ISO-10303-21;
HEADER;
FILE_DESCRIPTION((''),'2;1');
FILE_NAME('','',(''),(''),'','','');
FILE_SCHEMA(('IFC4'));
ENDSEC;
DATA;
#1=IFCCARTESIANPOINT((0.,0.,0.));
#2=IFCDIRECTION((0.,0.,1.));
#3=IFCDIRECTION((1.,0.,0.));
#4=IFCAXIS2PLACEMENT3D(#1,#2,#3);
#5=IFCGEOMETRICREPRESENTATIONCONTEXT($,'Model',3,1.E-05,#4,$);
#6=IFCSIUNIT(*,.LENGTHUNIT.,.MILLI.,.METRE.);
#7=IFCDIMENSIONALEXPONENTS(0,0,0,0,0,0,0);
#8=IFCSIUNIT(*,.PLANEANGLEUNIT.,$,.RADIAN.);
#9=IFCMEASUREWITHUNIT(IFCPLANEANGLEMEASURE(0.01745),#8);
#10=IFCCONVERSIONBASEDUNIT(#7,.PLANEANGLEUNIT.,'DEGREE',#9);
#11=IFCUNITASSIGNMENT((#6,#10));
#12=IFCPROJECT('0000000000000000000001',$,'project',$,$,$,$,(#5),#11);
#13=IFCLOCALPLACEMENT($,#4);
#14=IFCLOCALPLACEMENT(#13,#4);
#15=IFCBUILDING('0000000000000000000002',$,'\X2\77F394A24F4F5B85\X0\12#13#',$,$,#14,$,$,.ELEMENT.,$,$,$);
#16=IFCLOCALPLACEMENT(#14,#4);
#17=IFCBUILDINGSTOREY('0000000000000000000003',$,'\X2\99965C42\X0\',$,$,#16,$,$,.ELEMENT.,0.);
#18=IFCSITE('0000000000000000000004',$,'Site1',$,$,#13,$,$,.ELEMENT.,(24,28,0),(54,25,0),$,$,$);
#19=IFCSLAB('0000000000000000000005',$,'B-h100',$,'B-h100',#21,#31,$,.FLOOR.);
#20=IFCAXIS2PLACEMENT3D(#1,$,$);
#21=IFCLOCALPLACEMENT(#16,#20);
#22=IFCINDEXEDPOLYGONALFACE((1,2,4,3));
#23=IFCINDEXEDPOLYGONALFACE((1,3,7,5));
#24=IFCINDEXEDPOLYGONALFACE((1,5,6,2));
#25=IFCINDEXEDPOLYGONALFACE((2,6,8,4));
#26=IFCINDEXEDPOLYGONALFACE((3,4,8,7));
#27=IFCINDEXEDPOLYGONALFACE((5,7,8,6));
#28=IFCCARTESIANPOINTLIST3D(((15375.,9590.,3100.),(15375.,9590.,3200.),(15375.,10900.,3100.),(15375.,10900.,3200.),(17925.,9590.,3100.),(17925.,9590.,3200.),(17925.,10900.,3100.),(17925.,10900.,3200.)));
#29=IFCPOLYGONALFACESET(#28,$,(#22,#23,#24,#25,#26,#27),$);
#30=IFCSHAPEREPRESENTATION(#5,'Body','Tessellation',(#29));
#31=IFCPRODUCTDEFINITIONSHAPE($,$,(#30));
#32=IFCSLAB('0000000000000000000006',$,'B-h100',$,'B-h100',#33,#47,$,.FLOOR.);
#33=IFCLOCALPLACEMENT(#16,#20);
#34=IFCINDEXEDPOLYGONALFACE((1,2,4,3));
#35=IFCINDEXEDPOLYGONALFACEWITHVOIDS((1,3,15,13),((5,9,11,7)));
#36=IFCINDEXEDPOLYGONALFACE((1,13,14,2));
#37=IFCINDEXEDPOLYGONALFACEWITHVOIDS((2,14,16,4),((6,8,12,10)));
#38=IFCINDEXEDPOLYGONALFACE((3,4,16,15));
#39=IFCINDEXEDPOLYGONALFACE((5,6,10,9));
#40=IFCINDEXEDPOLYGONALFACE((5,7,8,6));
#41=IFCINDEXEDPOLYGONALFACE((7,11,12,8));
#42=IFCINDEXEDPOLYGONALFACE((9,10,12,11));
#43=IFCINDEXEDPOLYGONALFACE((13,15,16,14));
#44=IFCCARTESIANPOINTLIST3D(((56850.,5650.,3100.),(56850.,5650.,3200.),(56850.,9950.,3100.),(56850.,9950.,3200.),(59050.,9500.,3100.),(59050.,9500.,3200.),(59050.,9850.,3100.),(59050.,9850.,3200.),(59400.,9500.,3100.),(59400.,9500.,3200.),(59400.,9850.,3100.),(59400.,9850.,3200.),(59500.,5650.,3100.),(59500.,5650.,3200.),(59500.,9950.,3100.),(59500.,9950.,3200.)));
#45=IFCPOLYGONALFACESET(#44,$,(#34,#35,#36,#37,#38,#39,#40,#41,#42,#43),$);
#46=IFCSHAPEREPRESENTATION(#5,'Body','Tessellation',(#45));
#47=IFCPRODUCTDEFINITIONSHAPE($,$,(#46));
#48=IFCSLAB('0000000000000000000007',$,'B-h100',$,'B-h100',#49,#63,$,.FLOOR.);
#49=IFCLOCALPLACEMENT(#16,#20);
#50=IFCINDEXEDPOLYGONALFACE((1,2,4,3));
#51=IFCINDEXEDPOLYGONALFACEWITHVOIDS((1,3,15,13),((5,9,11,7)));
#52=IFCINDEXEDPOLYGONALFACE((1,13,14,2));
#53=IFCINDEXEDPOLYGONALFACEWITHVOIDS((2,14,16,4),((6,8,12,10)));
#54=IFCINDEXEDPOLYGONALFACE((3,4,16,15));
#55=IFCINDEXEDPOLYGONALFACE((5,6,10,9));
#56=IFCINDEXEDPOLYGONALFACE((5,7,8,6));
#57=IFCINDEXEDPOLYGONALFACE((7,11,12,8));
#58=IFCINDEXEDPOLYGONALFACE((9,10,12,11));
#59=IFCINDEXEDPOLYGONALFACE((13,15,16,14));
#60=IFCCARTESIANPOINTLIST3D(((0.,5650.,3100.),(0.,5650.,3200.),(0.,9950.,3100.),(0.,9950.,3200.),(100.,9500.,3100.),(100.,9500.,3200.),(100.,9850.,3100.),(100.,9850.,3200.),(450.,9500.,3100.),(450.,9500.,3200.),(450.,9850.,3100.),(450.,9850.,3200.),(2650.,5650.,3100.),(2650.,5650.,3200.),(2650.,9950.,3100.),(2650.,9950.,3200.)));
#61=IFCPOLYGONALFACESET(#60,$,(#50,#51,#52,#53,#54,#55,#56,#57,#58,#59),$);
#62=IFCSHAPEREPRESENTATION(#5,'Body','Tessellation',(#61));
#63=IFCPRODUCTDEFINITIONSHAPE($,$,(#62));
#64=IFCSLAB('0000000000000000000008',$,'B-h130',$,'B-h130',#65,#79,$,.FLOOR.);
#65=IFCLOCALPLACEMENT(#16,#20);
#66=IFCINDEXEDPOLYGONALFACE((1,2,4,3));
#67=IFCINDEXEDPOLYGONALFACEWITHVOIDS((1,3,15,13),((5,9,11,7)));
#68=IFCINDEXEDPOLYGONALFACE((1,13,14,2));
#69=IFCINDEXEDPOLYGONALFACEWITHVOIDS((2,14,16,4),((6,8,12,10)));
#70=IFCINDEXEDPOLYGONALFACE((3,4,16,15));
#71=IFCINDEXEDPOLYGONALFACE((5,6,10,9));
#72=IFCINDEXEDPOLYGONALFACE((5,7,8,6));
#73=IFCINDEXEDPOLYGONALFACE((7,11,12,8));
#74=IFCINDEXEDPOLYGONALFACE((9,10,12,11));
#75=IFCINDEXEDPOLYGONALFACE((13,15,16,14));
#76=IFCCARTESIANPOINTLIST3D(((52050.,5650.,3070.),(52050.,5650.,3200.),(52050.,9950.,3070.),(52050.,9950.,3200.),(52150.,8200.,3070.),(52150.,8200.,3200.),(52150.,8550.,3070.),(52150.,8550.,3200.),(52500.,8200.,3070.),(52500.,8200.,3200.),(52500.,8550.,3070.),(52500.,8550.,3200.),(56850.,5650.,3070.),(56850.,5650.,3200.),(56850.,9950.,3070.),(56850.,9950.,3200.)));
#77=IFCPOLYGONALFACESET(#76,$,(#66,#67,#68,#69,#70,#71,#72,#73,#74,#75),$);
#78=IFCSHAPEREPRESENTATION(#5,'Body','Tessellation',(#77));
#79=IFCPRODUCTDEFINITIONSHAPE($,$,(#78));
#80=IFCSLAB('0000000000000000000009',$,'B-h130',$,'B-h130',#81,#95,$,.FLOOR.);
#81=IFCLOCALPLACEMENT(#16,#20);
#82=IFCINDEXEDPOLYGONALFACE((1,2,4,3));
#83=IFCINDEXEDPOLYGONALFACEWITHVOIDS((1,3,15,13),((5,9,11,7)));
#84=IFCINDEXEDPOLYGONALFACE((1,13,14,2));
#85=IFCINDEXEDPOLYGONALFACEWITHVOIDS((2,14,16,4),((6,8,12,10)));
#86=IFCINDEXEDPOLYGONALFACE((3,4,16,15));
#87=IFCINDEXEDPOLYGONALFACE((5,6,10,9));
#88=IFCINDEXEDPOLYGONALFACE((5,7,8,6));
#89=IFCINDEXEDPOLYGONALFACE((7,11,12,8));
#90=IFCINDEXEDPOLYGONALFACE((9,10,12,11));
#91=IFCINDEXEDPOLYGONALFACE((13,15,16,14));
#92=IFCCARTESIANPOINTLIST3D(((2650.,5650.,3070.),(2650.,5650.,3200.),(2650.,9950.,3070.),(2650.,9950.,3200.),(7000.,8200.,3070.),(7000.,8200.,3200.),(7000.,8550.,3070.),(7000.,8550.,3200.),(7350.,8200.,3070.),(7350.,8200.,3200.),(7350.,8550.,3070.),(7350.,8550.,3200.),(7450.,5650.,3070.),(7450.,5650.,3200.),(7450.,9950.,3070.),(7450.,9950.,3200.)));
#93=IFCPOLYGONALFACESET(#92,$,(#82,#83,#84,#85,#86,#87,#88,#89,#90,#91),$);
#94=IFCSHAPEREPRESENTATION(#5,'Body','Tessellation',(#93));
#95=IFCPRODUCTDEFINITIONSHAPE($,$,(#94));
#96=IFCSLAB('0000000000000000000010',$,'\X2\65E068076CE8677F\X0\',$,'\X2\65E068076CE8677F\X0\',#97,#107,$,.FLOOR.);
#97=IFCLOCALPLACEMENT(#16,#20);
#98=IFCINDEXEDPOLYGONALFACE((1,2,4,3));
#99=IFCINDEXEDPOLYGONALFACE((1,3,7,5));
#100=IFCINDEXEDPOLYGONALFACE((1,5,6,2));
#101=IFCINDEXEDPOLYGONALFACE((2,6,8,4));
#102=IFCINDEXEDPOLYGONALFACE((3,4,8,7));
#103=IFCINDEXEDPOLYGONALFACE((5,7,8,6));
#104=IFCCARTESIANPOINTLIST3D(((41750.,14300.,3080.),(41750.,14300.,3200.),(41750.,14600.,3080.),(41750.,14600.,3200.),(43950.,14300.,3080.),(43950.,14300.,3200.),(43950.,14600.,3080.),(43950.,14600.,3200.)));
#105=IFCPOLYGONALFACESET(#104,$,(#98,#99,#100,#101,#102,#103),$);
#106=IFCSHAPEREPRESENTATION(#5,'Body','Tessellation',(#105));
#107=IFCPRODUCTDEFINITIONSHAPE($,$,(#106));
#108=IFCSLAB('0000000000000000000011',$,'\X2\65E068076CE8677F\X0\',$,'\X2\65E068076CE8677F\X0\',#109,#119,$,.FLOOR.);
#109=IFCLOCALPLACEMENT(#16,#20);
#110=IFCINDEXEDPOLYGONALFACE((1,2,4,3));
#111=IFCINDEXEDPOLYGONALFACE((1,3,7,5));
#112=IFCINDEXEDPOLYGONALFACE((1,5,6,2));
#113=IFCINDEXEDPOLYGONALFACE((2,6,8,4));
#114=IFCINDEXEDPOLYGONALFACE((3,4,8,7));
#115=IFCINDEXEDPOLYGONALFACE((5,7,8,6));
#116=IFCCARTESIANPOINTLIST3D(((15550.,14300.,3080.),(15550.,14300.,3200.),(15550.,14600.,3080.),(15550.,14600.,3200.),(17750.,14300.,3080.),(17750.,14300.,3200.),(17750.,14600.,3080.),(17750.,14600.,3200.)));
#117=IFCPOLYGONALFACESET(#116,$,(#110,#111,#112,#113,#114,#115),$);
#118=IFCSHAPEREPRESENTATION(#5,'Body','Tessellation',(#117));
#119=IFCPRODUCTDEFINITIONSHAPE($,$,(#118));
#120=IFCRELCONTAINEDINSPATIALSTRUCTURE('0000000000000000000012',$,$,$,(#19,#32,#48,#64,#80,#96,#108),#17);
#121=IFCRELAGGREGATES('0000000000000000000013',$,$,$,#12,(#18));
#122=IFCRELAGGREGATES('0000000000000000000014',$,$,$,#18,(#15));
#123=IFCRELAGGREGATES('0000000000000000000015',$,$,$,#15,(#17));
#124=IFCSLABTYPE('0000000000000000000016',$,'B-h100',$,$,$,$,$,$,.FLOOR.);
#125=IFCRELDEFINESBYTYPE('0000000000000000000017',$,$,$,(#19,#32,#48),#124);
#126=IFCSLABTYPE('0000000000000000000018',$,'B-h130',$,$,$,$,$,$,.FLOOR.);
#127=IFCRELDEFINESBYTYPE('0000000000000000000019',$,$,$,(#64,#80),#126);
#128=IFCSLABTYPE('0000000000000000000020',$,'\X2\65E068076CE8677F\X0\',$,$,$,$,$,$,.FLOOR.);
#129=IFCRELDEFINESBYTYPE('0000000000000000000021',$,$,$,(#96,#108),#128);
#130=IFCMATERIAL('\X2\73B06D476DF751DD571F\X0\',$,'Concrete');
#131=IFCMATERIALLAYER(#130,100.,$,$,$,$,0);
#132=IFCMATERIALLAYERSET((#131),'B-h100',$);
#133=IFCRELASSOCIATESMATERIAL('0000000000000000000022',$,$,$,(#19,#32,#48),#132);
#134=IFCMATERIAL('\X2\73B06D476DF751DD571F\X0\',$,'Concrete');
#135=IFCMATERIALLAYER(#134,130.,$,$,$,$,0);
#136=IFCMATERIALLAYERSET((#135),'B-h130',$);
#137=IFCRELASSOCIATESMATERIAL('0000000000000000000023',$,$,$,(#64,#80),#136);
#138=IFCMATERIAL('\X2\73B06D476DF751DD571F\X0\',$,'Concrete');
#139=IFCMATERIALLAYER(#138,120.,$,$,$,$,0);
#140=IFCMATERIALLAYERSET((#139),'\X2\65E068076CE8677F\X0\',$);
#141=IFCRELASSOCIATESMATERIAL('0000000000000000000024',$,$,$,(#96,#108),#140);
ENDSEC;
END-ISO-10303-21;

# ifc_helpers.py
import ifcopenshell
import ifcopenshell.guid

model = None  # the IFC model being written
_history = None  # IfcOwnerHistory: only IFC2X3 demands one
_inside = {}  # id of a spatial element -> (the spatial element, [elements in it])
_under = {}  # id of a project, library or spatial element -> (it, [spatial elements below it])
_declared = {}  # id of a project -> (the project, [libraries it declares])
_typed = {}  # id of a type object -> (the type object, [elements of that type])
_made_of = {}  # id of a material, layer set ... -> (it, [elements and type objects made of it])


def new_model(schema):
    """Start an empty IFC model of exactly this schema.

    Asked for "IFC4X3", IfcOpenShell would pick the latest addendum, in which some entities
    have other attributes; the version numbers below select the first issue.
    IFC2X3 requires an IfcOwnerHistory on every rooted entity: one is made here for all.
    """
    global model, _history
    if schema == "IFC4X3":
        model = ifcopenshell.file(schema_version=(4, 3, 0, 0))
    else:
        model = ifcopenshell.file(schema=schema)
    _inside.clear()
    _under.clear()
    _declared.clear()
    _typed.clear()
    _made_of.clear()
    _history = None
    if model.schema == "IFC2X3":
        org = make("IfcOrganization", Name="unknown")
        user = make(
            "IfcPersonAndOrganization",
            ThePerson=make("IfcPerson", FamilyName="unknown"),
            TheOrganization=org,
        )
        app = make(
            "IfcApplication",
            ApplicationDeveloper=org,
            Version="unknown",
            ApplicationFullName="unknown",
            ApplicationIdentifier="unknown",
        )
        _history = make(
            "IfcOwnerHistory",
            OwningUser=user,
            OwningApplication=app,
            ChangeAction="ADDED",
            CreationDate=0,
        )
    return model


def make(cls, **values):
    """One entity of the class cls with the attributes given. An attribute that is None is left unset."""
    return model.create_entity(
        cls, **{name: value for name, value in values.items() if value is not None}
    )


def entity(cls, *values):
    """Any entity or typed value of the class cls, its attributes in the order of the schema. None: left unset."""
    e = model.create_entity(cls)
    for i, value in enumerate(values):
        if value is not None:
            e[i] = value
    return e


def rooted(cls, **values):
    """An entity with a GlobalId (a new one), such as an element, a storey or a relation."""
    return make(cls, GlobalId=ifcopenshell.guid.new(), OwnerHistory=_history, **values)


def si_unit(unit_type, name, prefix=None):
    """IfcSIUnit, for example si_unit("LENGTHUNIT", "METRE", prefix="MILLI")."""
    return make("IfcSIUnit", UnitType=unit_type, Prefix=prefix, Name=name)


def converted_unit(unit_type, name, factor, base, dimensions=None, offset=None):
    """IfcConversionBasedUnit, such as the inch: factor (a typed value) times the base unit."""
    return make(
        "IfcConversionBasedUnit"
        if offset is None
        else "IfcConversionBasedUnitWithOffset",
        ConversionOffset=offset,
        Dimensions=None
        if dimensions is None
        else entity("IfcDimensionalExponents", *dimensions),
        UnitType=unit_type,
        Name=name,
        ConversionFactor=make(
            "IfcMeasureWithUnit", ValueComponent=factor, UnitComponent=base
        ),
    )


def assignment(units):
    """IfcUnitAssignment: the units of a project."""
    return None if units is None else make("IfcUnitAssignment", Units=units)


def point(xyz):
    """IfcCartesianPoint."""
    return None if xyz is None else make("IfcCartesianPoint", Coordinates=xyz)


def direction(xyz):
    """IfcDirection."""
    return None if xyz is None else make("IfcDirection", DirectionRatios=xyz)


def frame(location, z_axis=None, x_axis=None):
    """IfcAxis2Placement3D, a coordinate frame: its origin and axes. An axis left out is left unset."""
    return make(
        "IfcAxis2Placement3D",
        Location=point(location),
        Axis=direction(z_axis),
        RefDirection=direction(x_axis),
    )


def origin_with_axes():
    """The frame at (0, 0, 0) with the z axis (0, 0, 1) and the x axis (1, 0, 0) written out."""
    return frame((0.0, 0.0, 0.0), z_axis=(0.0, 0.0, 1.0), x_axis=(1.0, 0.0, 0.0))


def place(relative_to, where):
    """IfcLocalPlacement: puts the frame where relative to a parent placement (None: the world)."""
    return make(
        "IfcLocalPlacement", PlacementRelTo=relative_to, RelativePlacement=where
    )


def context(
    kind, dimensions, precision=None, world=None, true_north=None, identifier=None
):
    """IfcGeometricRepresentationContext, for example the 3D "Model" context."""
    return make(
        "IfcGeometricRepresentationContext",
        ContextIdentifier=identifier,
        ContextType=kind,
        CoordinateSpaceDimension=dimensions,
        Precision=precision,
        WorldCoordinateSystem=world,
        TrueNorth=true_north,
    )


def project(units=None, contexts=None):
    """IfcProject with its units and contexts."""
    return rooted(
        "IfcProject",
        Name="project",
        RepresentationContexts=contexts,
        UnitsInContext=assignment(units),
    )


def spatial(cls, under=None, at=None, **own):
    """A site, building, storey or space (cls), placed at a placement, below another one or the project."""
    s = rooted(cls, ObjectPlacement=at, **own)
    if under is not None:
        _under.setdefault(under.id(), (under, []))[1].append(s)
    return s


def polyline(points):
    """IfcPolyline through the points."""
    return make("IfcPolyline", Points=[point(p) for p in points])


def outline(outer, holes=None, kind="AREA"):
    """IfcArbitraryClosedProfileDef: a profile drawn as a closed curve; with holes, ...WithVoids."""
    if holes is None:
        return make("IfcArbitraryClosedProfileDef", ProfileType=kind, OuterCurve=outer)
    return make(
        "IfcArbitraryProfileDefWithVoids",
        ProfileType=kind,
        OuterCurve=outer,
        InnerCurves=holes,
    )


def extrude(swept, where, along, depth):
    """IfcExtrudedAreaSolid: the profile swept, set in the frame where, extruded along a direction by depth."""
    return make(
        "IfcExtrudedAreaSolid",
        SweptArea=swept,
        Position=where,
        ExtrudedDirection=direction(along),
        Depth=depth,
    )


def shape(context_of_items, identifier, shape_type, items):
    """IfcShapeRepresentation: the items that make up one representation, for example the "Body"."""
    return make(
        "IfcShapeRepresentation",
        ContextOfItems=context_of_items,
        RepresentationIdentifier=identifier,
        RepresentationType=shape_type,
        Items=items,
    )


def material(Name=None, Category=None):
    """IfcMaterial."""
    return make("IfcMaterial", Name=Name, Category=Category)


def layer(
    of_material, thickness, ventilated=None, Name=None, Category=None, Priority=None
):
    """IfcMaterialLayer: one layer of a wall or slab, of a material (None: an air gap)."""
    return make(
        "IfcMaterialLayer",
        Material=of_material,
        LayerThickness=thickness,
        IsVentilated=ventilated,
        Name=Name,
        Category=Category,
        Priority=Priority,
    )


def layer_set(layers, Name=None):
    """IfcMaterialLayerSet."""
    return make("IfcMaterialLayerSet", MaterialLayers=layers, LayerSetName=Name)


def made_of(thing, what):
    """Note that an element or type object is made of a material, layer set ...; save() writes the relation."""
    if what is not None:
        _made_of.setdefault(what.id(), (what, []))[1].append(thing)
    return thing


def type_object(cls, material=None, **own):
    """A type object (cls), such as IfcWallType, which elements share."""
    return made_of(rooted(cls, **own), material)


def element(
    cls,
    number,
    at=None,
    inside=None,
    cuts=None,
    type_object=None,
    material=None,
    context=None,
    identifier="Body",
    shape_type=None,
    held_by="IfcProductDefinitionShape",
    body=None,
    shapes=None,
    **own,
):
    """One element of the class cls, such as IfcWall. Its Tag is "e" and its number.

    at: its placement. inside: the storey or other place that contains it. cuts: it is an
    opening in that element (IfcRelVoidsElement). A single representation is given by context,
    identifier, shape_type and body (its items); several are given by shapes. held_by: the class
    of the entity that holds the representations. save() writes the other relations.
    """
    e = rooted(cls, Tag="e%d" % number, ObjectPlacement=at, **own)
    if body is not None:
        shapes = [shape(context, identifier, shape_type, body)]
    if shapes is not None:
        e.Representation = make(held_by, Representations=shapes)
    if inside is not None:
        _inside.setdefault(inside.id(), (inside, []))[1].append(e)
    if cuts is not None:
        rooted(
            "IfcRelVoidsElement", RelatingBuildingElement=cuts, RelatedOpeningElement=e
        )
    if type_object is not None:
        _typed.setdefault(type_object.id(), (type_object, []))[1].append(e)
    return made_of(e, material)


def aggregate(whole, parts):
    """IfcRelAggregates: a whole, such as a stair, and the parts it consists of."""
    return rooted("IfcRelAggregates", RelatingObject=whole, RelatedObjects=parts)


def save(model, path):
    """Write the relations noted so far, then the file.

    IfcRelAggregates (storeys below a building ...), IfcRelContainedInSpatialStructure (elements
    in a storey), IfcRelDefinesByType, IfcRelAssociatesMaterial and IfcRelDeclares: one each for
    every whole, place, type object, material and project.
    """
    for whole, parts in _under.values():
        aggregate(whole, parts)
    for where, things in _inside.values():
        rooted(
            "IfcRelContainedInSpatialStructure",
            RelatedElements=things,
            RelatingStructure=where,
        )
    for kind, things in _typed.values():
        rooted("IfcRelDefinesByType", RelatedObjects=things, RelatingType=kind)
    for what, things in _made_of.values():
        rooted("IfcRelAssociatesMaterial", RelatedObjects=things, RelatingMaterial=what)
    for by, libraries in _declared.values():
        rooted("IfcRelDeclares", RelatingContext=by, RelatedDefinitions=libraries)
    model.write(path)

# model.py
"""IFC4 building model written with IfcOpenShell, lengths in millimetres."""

from ifc_helpers import new_model, entity, si_unit, converted_unit, frame, origin_with_axes, place, context, project, spatial, polyline, outline, extrude, material, layer, layer_set, type_object, element, save


model = new_model("IFC4")

# Units and contexts
model_context = context("Model", 3, precision=1e-05, world=origin_with_axes())
ifc_project = project(units=[si_unit("LENGTHUNIT", "METRE", prefix="MILLI"), converted_unit("PLANEANGLEUNIT", "DEGREE", entity("IfcPlaneAngleMeasure", 0.01745), si_unit("PLANEANGLEUNIT", "RADIAN"), dimensions=[0, 0, 0, 0, 0, 0, 0])], contexts=[model_context])

# Site, building, storey
site_placement = place(None, origin_with_axes())
site = spatial("IfcSite", under=ifc_project, at=site_placement, Name="Site1", CompositionType="ELEMENT", RefLatitude=(24, 28, 0), RefLongitude=(54, 25, 0))
building_placement = place(site_placement, origin_with_axes())
building = spatial("IfcBuilding", under=site, at=building_placement, Name="石钢住宅12#13#", CompositionType="ELEMENT")
storey_placement = place(building_placement, origin_with_axes())
storey = spatial("IfcBuildingStorey", under=building, at=storey_placement, Name="首层", CompositionType="ELEMENT", Elevation=0.0)

# Slab
ifc_material_1 = material(Name="现浇混凝土", Category="Concrete")
ifc_layer_1 = layer(ifc_material_1, 100.0, Priority=0)
ifc_layer_set_1 = layer_set([ifc_layer_1], Name="B-h100")
slab_type_1 = type_object("IfcSlabType", Name="B-h100", PredefinedType="FLOOR")
slab_1_placement = place(storey_placement, origin_with_axes())
element("IfcSlab", 1, at=slab_1_placement, inside=storey, type_object=slab_type_1, material=ifc_layer_set_1, Name="B-h100", ObjectType="B-h100", PredefinedType="FLOOR", context=model_context, shape_type="SweptSolid", body=[
    extrude(outline(polyline([(0.0, 0.0), (2550.0, 0.0), (2550.0, 1310.0), (0.0, 1310.0), (0.0, 0.0)])), frame((17925.0, 9590.0, 3200.0), z_axis=(0.0, 0.0, -1.0), x_axis=(-1.0, 0.0, 0.0)), (0.0, 0.0, 1.0), 100.0),
])

# Slabs, openings
slab_2_placement = place(storey_placement, origin_with_axes())
slab_2 = element("IfcSlab", 2, at=slab_2_placement, inside=storey, type_object=slab_type_1, material=ifc_layer_set_1, Name="B-h100", ObjectType="B-h100", PredefinedType="FLOOR", context=model_context, shape_type="SweptSolid", body=[
    extrude(outline(polyline([(0.0, 0.0), (2650.0, 0.0), (2650.0, 4300.0), (0.0, 4300.0), (0.0, 0.0)])), frame((56850.0, 9950.0, 3200.0), z_axis=(0.0, 0.0, -1.0), x_axis=(1.0, 0.0, 0.0)), (0.0, 0.0, 1.0), 100.0),
])
opening_1_placement = place(storey_placement, origin_with_axes())
element("IfcOpeningElement", 3, at=opening_1_placement, cuts=slab_2, PredefinedType="OPENING", context=model_context, shape_type="SweptSolid", body=[
    extrude(outline(polyline([(0.0, 0.0), (350.0, 0.0), (350.0, 350.0), (0.0, 350.0), (0.0, 0.0)])), frame((59400.0, 9500.0, -6400.0), z_axis=(0.0, 0.0, 1.0), x_axis=(0.0, 1.0, 0.0)), (0.0, 0.0, 1.0), 19200.0),
])
slab_3_placement = place(storey_placement, origin_with_axes())
slab_3 = element("IfcSlab", 4, at=slab_3_placement, inside=storey, type_object=slab_type_1, material=ifc_layer_set_1, Name="B-h100", ObjectType="B-h100", PredefinedType="FLOOR", context=model_context, shape_type="SweptSolid", body=[
    extrude(outline(polyline([(0.0, 0.0), (4300.0, 0.0), (4300.0, 2650.0), (0.0, 2650.0), (0.0, 0.0)])), frame((2650.0, 9950.0, 3200.0), z_axis=(0.0, 0.0, -1.0), x_axis=(0.0, -1.0, 0.0)), (0.0, 0.0, 1.0), 100.0),
])
opening_2_placement = place(storey_placement, origin_with_axes())
element("IfcOpeningElement", 5, at=opening_2_placement, cuts=slab_3, PredefinedType="OPENING", context=model_context, shape_type="SweptSolid", body=[
    extrude(outline(polyline([(0.0, 0.0), (350.0, 0.0), (350.0, 350.0), (0.0, 350.0), (0.0, 0.0)])), frame((100.0, 9500.0, -6400.0), z_axis=(0.0, 0.0, 1.0), x_axis=(1.0, 0.0, 0.0)), (0.0, 0.0, 1.0), 19200.0),
])
ifc_material_2 = material(Name="现浇混凝土", Category="Concrete")
ifc_layer_2 = layer(ifc_material_2, 130.0, Priority=0)
ifc_layer_set_2 = layer_set([ifc_layer_2], Name="B-h130")
slab_type_2 = type_object("IfcSlabType", Name="B-h130", PredefinedType="FLOOR")
slab_4_placement = place(storey_placement, origin_with_axes())
slab_4 = element("IfcSlab", 6, at=slab_4_placement, inside=storey, type_object=slab_type_2, material=ifc_layer_set_2, Name="B-h130", ObjectType="B-h130", PredefinedType="FLOOR", context=model_context, shape_type="SweptSolid", body=[
    extrude(outline(polyline([(0.0, 0.0), (4300.0, 0.0), (4300.0, 4800.0), (0.0, 4800.0), (0.0, 0.0)])), frame((56850.0, 9950.0, 3200.0), z_axis=(0.0, 0.0, -1.0), x_axis=(0.0, -1.0, 0.0)), (0.0, 0.0, 1.0), 130.0),
])
opening_3_placement = place(storey_placement, origin_with_axes())
element("IfcOpeningElement", 7, at=opening_3_placement, cuts=slab_4, PredefinedType="OPENING", context=model_context, shape_type="SweptSolid", body=[
    extrude(outline(polyline([(0.0, 0.0), (350.0, 0.0), (350.0, 350.0), (0.0, 350.0), (0.0, 0.0)])), frame((52500.0, 8200.0, -12800.0), z_axis=(0.0, 0.0, 1.0), x_axis=(0.0, 1.0, 0.0)), (0.0, 0.0, 1.0), 32000.0),
])
slab_5_placement = place(storey_placement, origin_with_axes())
slab_5 = element("IfcSlab", 8, at=slab_5_placement, inside=storey, type_object=slab_type_2, material=ifc_layer_set_2, Name="B-h130", ObjectType="B-h130", PredefinedType="FLOOR", context=model_context, shape_type="SweptSolid", body=[
    extrude(outline(polyline([(0.0, 0.0), (4800.0, 0.0), (4800.0, 4300.0), (0.0, 4300.0), (0.0, 0.0)])), frame((2650.0, 9950.0, 3200.0), z_axis=(0.0, 0.0, -1.0), x_axis=(1.0, 0.0, 0.0)), (0.0, 0.0, 1.0), 130.0),
])
opening_4_placement = place(storey_placement, origin_with_axes())
element("IfcOpeningElement", 9, at=opening_4_placement, cuts=slab_5, PredefinedType="OPENING", context=model_context, shape_type="SweptSolid", body=[
    extrude(outline(polyline([(0.0, 0.0), (350.0, 0.0), (350.0, 350.0), (0.0, 350.0), (0.0, 0.0)])), frame((7000.0, 8200.0, -12800.0), z_axis=(0.0, 0.0, 1.0), x_axis=(1.0, 0.0, 0.0)), (0.0, 0.0, 1.0), 32000.0),
])

# Slabs
ifc_material_3 = material(Name="现浇混凝土", Category="Concrete")
ifc_layer_3 = layer(ifc_material_3, 120.0, Priority=0)
ifc_layer_set_3 = layer_set([ifc_layer_3], Name="无标注板")
slab_type_3 = type_object("IfcSlabType", Name="无标注板", PredefinedType="FLOOR")
slab_6_placement = place(storey_placement, origin_with_axes())
element("IfcSlab", 10, at=slab_6_placement, inside=storey, type_object=slab_type_3, material=ifc_layer_set_3, Name="无标注板", ObjectType="无标注板", PredefinedType="FLOOR", context=model_context, shape_type="SweptSolid", body=[
    extrude(outline(polyline([(0.0, 0.0), (2200.0, 0.0), (2200.0, 300.0), (0.0, 300.0), (0.0, 0.0)])), frame((43950.0, 14300.0, 3200.0), z_axis=(0.0, 0.0, -1.0), x_axis=(-1.0, 0.0, 0.0)), (0.0, 0.0, 1.0), 120.0),
])
slab_7_placement = place(storey_placement, origin_with_axes())
element("IfcSlab", 11, at=slab_7_placement, inside=storey, type_object=slab_type_3, material=ifc_layer_set_3, Name="无标注板", ObjectType="无标注板", PredefinedType="FLOOR", context=model_context, shape_type="SweptSolid", body=[
    extrude(outline(polyline([(0.0, 0.0), (300.0, 0.0), (300.0, 2200.0), (0.0, 2200.0), (0.0, 0.0)])), frame((15550.0, 14300.0, 3200.0), z_axis=(0.0, 0.0, -1.0), x_axis=(0.0, 1.0, 0.0)), (0.0, 0.0, 1.0), 120.0),
])

save(model, "model.ifc")
